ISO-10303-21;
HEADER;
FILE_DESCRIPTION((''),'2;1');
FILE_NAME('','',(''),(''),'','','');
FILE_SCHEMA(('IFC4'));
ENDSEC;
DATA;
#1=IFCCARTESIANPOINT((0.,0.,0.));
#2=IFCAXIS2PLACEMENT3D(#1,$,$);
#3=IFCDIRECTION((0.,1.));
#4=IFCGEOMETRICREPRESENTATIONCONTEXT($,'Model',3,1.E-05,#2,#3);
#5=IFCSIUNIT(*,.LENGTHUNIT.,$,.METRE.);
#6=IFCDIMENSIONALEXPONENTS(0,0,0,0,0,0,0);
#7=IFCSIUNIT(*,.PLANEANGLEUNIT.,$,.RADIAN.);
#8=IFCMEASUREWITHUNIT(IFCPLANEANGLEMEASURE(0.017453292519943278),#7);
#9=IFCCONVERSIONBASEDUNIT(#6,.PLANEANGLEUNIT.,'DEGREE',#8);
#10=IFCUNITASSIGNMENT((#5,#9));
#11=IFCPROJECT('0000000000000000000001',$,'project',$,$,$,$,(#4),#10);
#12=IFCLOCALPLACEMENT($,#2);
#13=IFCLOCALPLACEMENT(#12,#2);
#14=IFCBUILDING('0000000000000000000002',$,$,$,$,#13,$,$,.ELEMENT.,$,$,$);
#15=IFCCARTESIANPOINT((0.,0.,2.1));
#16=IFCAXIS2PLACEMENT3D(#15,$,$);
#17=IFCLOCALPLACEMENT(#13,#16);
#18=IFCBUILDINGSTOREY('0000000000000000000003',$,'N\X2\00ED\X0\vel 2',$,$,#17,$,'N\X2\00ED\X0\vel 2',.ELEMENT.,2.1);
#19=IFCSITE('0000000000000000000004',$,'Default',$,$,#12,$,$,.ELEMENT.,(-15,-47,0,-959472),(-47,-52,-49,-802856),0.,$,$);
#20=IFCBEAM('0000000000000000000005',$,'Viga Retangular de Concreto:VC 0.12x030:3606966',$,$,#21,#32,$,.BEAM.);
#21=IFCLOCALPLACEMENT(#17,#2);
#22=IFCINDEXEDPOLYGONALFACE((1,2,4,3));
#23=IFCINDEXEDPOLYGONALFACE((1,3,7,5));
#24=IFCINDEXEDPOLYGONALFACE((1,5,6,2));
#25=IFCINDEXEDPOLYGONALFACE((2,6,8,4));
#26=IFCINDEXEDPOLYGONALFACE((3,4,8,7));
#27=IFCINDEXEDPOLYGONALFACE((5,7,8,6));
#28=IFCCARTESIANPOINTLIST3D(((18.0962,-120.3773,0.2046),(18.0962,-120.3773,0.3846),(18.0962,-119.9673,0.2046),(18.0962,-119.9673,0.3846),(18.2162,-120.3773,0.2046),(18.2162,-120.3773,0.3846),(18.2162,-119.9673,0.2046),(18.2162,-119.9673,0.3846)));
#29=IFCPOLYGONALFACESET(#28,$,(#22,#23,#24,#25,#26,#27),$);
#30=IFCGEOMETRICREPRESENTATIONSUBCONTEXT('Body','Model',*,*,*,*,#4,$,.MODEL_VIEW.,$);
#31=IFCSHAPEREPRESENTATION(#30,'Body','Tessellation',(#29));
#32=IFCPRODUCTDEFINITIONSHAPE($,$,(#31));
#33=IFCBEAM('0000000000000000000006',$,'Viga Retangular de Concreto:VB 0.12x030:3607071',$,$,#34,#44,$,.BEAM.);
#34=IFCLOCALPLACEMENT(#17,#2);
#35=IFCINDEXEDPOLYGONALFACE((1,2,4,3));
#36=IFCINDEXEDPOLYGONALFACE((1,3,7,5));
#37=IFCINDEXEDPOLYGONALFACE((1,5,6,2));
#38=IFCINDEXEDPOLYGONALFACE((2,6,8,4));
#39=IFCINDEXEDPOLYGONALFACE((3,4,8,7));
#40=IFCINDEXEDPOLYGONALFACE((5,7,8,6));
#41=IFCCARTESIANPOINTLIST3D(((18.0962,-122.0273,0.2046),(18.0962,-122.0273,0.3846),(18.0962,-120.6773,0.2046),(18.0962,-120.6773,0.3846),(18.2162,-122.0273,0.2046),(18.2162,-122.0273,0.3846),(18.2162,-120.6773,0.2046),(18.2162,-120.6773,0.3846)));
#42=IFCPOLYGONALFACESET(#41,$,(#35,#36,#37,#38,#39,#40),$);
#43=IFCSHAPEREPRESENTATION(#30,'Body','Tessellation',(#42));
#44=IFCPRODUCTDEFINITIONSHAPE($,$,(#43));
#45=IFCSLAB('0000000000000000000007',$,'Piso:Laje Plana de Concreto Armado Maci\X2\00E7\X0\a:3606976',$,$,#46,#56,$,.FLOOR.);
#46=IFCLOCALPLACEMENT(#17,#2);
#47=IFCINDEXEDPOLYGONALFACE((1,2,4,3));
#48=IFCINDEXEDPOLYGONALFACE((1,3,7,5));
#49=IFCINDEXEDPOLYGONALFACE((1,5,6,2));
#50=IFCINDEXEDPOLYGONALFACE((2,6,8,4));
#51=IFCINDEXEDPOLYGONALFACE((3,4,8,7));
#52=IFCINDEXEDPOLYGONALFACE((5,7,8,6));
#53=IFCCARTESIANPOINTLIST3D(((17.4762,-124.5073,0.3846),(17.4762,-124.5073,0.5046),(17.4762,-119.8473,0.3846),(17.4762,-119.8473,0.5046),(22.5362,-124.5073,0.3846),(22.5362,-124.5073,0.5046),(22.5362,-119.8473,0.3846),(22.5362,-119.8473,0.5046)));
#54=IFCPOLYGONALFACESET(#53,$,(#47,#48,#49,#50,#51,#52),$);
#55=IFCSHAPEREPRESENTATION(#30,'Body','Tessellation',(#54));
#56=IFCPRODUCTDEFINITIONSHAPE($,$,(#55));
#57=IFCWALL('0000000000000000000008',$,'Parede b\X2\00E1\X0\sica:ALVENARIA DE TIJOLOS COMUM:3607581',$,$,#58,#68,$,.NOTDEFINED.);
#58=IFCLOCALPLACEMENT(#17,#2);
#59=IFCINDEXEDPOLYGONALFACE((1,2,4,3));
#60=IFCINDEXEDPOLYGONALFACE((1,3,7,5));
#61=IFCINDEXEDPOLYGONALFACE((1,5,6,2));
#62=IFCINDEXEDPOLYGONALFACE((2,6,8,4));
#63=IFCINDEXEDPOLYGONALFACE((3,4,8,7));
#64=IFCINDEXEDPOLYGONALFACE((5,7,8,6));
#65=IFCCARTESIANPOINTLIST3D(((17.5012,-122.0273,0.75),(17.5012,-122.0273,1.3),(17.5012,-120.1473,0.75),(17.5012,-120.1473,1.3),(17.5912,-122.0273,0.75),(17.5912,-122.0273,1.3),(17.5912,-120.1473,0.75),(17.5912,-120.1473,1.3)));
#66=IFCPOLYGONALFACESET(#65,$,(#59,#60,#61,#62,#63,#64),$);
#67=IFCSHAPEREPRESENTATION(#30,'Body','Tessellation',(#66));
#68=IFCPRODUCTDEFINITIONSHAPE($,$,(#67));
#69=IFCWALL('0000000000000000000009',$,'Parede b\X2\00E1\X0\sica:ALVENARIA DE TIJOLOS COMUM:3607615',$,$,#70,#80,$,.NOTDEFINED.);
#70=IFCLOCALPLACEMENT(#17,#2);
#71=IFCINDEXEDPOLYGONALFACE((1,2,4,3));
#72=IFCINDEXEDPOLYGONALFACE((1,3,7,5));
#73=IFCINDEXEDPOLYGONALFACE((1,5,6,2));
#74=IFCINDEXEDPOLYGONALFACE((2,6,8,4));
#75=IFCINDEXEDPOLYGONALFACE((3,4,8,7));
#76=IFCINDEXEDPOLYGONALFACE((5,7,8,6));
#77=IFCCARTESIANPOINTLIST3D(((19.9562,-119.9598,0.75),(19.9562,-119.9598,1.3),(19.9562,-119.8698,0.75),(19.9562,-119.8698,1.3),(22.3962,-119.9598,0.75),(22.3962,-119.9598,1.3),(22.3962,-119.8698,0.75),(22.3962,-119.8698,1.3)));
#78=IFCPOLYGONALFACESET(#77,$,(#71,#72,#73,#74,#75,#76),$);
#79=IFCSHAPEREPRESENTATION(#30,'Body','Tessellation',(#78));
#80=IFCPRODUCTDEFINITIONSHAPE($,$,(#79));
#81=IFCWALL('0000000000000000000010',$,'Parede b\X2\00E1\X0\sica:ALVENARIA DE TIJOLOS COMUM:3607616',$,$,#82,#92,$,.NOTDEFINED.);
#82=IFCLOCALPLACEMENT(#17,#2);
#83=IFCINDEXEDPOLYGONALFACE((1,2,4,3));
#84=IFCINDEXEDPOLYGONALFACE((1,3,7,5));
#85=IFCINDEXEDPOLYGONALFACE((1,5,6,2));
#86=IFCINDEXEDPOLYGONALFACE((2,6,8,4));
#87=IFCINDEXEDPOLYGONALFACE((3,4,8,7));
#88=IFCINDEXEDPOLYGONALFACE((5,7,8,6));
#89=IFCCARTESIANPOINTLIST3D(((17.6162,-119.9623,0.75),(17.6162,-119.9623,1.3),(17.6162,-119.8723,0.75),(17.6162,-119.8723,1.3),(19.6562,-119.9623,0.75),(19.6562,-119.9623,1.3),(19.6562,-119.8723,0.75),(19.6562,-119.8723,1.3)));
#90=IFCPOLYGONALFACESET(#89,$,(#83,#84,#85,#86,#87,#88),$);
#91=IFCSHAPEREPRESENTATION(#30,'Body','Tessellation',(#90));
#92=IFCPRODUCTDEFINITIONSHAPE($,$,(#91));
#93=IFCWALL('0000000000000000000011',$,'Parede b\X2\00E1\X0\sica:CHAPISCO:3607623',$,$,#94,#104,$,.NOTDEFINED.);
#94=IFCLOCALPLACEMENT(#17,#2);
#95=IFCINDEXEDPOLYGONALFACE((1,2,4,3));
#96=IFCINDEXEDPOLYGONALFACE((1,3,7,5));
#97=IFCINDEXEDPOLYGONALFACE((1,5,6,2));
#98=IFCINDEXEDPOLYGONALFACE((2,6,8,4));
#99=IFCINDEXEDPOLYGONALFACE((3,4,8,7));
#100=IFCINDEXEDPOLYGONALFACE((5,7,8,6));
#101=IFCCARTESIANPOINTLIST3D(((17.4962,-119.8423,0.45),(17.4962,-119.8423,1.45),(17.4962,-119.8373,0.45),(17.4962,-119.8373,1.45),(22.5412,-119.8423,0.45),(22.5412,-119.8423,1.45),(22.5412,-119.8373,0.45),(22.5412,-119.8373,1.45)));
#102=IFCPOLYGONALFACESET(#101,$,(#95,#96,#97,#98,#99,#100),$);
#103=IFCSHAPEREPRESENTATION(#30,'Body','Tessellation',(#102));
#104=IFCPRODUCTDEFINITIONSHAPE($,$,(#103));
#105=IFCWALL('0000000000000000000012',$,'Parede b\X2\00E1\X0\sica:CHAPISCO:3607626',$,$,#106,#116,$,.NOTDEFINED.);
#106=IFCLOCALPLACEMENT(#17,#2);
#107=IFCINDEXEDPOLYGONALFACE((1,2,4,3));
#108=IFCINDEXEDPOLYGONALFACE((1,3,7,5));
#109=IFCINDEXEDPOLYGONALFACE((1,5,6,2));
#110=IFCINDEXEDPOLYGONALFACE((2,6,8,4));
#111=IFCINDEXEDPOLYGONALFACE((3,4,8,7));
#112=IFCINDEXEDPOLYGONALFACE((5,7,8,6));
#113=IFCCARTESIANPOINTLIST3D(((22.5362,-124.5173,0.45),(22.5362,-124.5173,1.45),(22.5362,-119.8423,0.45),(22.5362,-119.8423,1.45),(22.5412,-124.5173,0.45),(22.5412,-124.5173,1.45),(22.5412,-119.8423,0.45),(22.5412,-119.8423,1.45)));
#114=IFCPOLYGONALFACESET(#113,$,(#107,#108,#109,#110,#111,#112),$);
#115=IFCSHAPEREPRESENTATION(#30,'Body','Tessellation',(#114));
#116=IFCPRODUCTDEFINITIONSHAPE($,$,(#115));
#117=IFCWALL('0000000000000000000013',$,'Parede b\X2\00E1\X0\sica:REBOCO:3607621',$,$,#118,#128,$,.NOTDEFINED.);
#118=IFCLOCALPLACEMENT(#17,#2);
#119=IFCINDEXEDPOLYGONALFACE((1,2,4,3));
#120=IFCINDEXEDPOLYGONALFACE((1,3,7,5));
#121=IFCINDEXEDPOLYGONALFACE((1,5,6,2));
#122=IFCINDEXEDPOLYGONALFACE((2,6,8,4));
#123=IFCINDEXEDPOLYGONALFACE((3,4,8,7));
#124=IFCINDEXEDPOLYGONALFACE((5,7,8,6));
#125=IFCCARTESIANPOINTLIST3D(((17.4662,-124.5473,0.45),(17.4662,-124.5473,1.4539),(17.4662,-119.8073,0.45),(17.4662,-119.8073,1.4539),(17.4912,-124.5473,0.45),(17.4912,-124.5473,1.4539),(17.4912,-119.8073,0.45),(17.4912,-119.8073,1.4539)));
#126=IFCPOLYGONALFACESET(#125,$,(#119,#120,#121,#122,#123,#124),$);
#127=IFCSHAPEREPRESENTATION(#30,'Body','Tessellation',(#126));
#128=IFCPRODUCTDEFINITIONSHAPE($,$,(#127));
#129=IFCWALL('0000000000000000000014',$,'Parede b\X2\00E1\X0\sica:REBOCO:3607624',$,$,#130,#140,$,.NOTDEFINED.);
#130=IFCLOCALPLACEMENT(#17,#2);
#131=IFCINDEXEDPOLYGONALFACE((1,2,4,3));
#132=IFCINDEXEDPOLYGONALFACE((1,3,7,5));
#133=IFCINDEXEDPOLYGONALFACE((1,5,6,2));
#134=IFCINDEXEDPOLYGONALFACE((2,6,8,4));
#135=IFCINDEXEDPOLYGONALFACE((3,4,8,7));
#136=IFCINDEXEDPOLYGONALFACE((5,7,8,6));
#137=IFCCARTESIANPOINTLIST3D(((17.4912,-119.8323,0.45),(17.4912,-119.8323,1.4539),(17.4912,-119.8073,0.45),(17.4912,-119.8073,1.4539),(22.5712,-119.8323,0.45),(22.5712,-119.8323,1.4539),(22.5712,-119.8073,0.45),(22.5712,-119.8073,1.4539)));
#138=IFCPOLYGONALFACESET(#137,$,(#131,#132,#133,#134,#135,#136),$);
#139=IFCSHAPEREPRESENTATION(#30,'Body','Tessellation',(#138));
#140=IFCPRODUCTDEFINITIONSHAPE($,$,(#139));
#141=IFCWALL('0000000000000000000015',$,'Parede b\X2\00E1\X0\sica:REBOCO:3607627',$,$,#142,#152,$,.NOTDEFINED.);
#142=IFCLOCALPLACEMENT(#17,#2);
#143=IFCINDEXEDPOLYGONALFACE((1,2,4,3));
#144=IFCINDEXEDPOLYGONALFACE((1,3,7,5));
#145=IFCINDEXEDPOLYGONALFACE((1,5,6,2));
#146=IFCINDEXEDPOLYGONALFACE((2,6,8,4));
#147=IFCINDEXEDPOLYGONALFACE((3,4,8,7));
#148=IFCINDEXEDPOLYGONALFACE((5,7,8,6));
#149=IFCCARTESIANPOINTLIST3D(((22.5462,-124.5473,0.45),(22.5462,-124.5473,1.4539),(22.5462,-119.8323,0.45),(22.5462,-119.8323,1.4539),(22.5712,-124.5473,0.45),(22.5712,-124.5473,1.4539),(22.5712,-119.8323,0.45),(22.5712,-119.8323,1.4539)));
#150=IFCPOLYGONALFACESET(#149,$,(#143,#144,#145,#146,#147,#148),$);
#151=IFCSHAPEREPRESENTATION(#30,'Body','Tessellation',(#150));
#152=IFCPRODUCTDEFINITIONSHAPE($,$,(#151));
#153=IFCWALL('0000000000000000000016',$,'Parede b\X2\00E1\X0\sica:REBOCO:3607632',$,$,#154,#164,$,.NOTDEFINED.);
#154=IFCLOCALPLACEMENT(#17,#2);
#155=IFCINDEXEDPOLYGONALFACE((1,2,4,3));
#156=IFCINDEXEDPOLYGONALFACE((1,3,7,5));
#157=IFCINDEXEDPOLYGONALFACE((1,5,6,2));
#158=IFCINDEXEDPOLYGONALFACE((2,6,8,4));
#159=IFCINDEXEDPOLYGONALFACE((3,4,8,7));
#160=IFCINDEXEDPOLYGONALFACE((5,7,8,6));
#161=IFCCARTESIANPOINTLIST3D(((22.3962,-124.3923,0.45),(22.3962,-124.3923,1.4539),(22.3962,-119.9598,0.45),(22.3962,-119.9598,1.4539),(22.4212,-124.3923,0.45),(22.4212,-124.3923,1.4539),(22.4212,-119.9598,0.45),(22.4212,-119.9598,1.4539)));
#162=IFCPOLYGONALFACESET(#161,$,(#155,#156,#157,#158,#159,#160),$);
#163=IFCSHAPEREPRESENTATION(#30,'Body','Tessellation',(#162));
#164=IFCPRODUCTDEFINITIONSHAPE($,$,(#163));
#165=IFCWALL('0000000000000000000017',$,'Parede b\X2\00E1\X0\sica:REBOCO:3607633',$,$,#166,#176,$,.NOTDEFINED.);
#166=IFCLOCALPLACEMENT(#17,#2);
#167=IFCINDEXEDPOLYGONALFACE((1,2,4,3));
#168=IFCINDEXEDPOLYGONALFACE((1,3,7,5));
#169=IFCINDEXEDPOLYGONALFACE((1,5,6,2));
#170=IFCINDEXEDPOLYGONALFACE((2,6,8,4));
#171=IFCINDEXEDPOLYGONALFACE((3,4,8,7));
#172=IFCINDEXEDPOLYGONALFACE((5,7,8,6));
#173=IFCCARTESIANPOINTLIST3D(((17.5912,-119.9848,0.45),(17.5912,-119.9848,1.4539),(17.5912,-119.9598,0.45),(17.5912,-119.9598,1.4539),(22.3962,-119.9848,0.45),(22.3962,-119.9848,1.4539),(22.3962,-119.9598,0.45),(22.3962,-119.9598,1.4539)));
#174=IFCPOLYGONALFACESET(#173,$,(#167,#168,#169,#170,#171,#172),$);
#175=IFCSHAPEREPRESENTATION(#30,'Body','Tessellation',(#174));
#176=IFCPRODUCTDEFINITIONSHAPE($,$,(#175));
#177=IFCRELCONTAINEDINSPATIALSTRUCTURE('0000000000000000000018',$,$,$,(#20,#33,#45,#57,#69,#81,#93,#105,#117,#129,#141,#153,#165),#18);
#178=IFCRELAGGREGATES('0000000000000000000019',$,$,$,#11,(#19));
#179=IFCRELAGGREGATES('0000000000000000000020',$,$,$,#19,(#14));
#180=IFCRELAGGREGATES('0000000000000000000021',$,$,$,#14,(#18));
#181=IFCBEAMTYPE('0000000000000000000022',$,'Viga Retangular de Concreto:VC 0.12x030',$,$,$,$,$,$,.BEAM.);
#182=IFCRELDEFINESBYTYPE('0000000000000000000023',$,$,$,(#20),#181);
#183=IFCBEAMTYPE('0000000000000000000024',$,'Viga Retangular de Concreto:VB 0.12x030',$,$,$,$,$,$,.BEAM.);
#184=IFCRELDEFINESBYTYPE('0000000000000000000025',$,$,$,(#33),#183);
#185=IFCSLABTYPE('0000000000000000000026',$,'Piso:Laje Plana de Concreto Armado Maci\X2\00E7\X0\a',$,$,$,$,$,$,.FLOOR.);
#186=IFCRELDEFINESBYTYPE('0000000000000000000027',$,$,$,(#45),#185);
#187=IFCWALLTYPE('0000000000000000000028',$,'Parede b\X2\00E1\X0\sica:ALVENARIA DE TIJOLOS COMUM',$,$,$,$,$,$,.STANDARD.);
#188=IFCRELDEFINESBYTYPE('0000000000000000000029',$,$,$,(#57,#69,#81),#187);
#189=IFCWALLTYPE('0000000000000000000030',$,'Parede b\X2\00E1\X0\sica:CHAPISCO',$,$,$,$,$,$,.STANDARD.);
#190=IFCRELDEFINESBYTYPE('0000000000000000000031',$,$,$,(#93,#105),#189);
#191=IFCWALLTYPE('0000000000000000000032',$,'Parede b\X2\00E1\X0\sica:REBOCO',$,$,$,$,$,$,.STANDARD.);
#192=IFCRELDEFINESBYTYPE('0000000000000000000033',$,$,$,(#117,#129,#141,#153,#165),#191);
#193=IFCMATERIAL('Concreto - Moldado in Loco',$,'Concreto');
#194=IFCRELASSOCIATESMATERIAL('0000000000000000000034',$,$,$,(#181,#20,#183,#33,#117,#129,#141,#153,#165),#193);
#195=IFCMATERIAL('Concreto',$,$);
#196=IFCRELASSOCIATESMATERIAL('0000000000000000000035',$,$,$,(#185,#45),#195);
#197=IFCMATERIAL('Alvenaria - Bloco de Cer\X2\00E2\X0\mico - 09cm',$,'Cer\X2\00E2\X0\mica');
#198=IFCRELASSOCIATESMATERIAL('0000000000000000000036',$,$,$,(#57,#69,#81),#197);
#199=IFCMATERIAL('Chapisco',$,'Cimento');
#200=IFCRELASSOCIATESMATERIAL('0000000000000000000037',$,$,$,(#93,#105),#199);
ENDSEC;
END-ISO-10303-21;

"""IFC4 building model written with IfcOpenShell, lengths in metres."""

from ifc_helpers import new_model, entity, si_unit, converted_unit, direction, frame, origin, place, context, subcontext, project, spatial, indexed_curve, outline, extrude, source, transform, mapped, material, type_object, type_shapes, element, save


model = new_model("IFC4")

# Units and contexts
model_context = context("Model", 3, precision=1e-05, world=origin(), true_north=direction((0.0, 1.0)))
body_context = subcontext(model_context, "Body", "Model", "MODEL_VIEW")
ifc_project = project(units=[si_unit("LENGTHUNIT", "METRE"), converted_unit("PLANEANGLEUNIT", "DEGREE", entity("IfcPlaneAngleMeasure", 0.017453292519943278), si_unit("PLANEANGLEUNIT", "RADIAN"), dimensions=[0, 0, 0, 0, 0, 0, 0])], contexts=[model_context])

# Site, building, storey
site_placement = place(None, origin())
site = spatial("IfcSite", under=ifc_project, at=site_placement, Name="Default", CompositionType="ELEMENT", RefLatitude=(-15, -47, 0, -959472), RefLongitude=(-47, -52, -49, -802856), RefElevation=0.0)
building_placement = place(site_placement, origin())
building = spatial("IfcBuilding", under=site, at=building_placement, CompositionType="ELEMENT")
storey_placement = place(building_placement, frame((0.0, 0.0, 2.1)))
storey = spatial("IfcBuildingStorey", under=building, at=storey_placement, Name="Nível 2", LongName="Nível 2", CompositionType="ELEMENT", Elevation=2.1)

# Beams
ifc_material_1 = material(Name="Concreto - Moldado in Loco", Category="Concreto")
beam_type_1 = type_object("IfcBeamType", Name="Viga Retangular de Concreto:VC 0.12x030", PredefinedType="BEAM", material=ifc_material_1)
shared_shape_1 = source(origin(), body_context, "Body", "SweptSolid", [
    extrude(outline(indexed_curve([(-0.06, -0.09), (0.06, -0.09), (0.06, 0.09), (-0.06, 0.09), (-0.06, -0.09)], self_intersect=False)), frame((18.1562, -120.3773, 2.3946), z_axis=(0.0, 1.0, 0.0), x_axis=(-1.0, 0.0, 0.0)), (0.0, 0.0, 1.0), 0.41),
])
type_shapes(beam_type_1, [shared_shape_1])
beam_1_placement = place(storey_placement, frame((0.0, 0.0, -2.1)))
element("IfcBeam", 1, at=beam_1_placement, inside=storey, type_object=beam_type_1, material=ifc_material_1, Name="Viga Retangular de Concreto:VC 0.12x030:3606966", PredefinedType="BEAM", context=body_context, shape_type="MappedRepresentation", body=[
    mapped(shared_shape_1, transform((0.0, 0.0, 0.0), scale=1.0)),
])
beam_type_2 = type_object("IfcBeamType", Name="Viga Retangular de Concreto:VB 0.12x030", PredefinedType="BEAM", material=ifc_material_1)
shared_shape_2 = source(origin(), body_context, "Body", "SweptSolid", [
    extrude(outline(indexed_curve([(-0.06, -0.09), (0.06, -0.09), (0.06, 0.09), (-0.06, 0.09), (-0.06, -0.09)], self_intersect=False)), frame((18.1562, -122.0273, 2.3946), z_axis=(0.0, 1.0, 0.0), x_axis=(-1.0, 0.0, 0.0)), (0.0, 0.0, 1.0), 1.35),
])
type_shapes(beam_type_2, [shared_shape_2])
beam_2_placement = place(storey_placement, frame((0.0, 0.0, -2.1)))
element("IfcBeam", 2, at=beam_2_placement, inside=storey, type_object=beam_type_2, material=ifc_material_1, Name="Viga Retangular de Concreto:VB 0.12x030:3607071", PredefinedType="BEAM", context=body_context, shape_type="MappedRepresentation", body=[
    mapped(shared_shape_2, transform((0.0, 0.0, 0.0), scale=1.0)),
])

# Slab
ifc_material_2 = material(Name="Concreto")
slab_type = type_object("IfcSlabType", Name="Piso:Laje Plana de Concreto Armado Maciça", PredefinedType="FLOOR", material=ifc_material_2)
slab_placement = place(storey_placement, origin())
element("IfcSlab", 3, at=slab_placement, inside=storey, type_object=slab_type, material=ifc_material_2, Name="Piso:Laje Plana de Concreto Armado Maciça:3606976", PredefinedType="FLOOR", context=body_context, shape_type="SweptSolid", body=[
    extrude(outline(indexed_curve([(-2.33, -2.53), (2.33, -2.53), (2.33, 2.53), (-2.33, 2.53), (-2.33, -2.53)], self_intersect=False)), frame((20.0062, -122.1773, 0.5046), z_axis=(0.0, 0.0, -1.0), x_axis=(0.0, 1.0, 0.0)), (0.0, 0.0, 1.0), 0.12),
])

# Walls
ifc_material_3 = material(Name="Alvenaria - Bloco de Cerâmico - 09cm", Category="Cerâmica")
wall_type_1 = type_object("IfcWallType", Name="Parede básica:ALVENARIA DE TIJOLOS COMUM", PredefinedType="STANDARD")
wall_1_placement = place(storey_placement, frame((17.5462, -120.1473, 0.75), z_axis=(0.0, 0.0, 1.0), x_axis=(0.0, -1.0, 0.0)))
element("IfcWall", 4, at=wall_1_placement, inside=storey, type_object=wall_type_1, material=ifc_material_3, Name="Parede básica:ALVENARIA DE TIJOLOS COMUM:3607581", PredefinedType="NOTDEFINED", context=body_context, shape_type="SweptSolid", body=[
    extrude(outline(indexed_curve([(1.88, 0.045), (0.0, 0.045), (0.0, -0.045), (1.88, -0.045), (1.88, 0.045)], self_intersect=False)), origin(), (0.0, 0.0, 1.0), 0.55),
])
wall_2_placement = place(storey_placement, frame((19.9562, -119.9148, 0.75)))
element("IfcWall", 5, at=wall_2_placement, inside=storey, type_object=wall_type_1, material=ifc_material_3, Name="Parede básica:ALVENARIA DE TIJOLOS COMUM:3607615", PredefinedType="NOTDEFINED", context=body_context, shape_type="SweptSolid", body=[
    extrude(outline(indexed_curve([(2.44, 0.045), (0.0, 0.045), (0.0, -0.045), (2.44, -0.045), (2.44, 0.045)], self_intersect=False)), origin(), (0.0, 0.0, 1.0), 0.55),
])
wall_3_placement = place(storey_placement, frame((19.6562, -119.9173, 0.75), z_axis=(0.0, 0.0, 1.0), x_axis=(-1.0, 0.0, 0.0)))
element("IfcWall", 6, at=wall_3_placement, inside=storey, type_object=wall_type_1, material=ifc_material_3, Name="Parede básica:ALVENARIA DE TIJOLOS COMUM:3607616", PredefinedType="NOTDEFINED", context=body_context, shape_type="SweptSolid", body=[
    extrude(outline(indexed_curve([(2.04, 0.045), (0.0, 0.045), (0.0, -0.045), (2.04, -0.045), (2.04, 0.045)], self_intersect=False)), origin(), (0.0, 0.0, 1.0), 0.55),
])
ifc_material_4 = material(Name="Chapisco", Category="Cimento")
wall_type_2 = type_object("IfcWallType", Name="Parede básica:CHAPISCO", PredefinedType="STANDARD")
wall_4_placement = place(storey_placement, frame((17.4962, -119.8398, 0.45)))
element("IfcWall", 7, at=wall_4_placement, inside=storey, type_object=wall_type_2, material=ifc_material_4, Name="Parede básica:CHAPISCO:3607623", PredefinedType="NOTDEFINED", context=body_context, shape_type="SweptSolid", body=[
    extrude(outline(indexed_curve([(5.045, 0.0025), (0.0, 0.0025), (0.0, -0.0025), (5.045, -0.0025), (5.045, 0.0025)], self_intersect=False)), origin(), (0.0, 0.0, 1.0), 1.0),
])
wall_5_placement = place(storey_placement, frame((22.5387, -119.8423, 0.45), z_axis=(0.0, 0.0, 1.0), x_axis=(0.0, -1.0, 0.0)))
element("IfcWall", 8, at=wall_5_placement, inside=storey, type_object=wall_type_2, material=ifc_material_4, Name="Parede básica:CHAPISCO:3607626", PredefinedType="NOTDEFINED", context=body_context, shape_type="SweptSolid", body=[
    extrude(outline(indexed_curve([(4.675, 0.0025), (0.0, 0.0025), (0.0, -0.0025), (4.675, -0.0025), (4.675, 0.0025)], self_intersect=False)), origin(), (0.0, 0.0, 1.0), 1.0),
])
wall_type_3 = type_object("IfcWallType", Name="Parede básica:REBOCO", PredefinedType="STANDARD")
wall_6_placement = place(storey_placement, frame((17.4787, -119.8073, 0.45), z_axis=(0.0, 0.0, 1.0), x_axis=(0.0, -1.0, 0.0)))
element("IfcWall", 9, at=wall_6_placement, inside=storey, type_object=wall_type_3, material=ifc_material_1, Name="Parede básica:REBOCO:3607621", PredefinedType="NOTDEFINED", context=body_context, shape_type="SweptSolid", body=[
    extrude(outline(indexed_curve([(4.74, 0.0125), (0.0, 0.0125), (0.0, -0.0125), (4.74, -0.0125), (4.74, 0.0125)], self_intersect=False)), origin(), (0.0, 0.0, 1.0), 1.0039),
])
wall_7_placement = place(storey_placement, frame((17.4912, -119.8198, 0.45)))
element("IfcWall", 10, at=wall_7_placement, inside=storey, type_object=wall_type_3, material=ifc_material_1, Name="Parede básica:REBOCO:3607624", PredefinedType="NOTDEFINED", context=body_context, shape_type="SweptSolid", body=[
    extrude(outline(indexed_curve([(5.08, 0.0125), (0.0, 0.0125), (0.0, -0.0125), (5.08, -0.0125), (5.08, 0.0125)], self_intersect=False)), origin(), (0.0, 0.0, 1.0), 1.0039),
])
wall_8_placement = place(storey_placement, frame((22.5587, -119.8323, 0.45), z_axis=(0.0, 0.0, 1.0), x_axis=(0.0, -1.0, 0.0)))
element("IfcWall", 11, at=wall_8_placement, inside=storey, type_object=wall_type_3, material=ifc_material_1, Name="Parede básica:REBOCO:3607627", PredefinedType="NOTDEFINED", context=body_context, shape_type="SweptSolid", body=[
    extrude(outline(indexed_curve([(4.715, 0.0125), (0.0, 0.0125), (0.0, -0.0125), (4.715, -0.0125), (4.715, 0.0125)], self_intersect=False)), origin(), (0.0, 0.0, 1.0), 1.0039),
])
wall_9_placement = place(storey_placement, frame((22.4087, -119.9598, 0.45), z_axis=(0.0, 0.0, 1.0), x_axis=(0.0, -1.0, 0.0)))
element("IfcWall", 12, at=wall_9_placement, inside=storey, type_object=wall_type_3, material=ifc_material_1, Name="Parede básica:REBOCO:3607632", PredefinedType="NOTDEFINED", context=body_context, shape_type="SweptSolid", body=[
    extrude(outline(indexed_curve([(4.4325, 0.0125), (0.0, 0.0125), (0.0, -0.0125), (4.4325, -0.0125), (4.4325, 0.0125)], self_intersect=False)), origin(), (0.0, 0.0, 1.0), 1.0039),
])
wall_10_placement = place(storey_placement, frame((22.3962, -119.9723, 0.45), z_axis=(0.0, 0.0, 1.0), x_axis=(-1.0, 0.0, 0.0)))
element("IfcWall", 13, at=wall_10_placement, inside=storey, type_object=wall_type_3, material=ifc_material_1, Name="Parede básica:REBOCO:3607633", PredefinedType="NOTDEFINED", context=body_context, shape_type="SweptSolid", body=[
    extrude(outline(indexed_curve([(4.805, 0.0125), (0.0, 0.0125), (0.0, -0.0125), (4.805, -0.0125), (4.805, 0.0125)], self_intersect=False)), origin(), (0.0, 0.0, 1.0), 1.0039),
])

save(model, "model.ifc")
